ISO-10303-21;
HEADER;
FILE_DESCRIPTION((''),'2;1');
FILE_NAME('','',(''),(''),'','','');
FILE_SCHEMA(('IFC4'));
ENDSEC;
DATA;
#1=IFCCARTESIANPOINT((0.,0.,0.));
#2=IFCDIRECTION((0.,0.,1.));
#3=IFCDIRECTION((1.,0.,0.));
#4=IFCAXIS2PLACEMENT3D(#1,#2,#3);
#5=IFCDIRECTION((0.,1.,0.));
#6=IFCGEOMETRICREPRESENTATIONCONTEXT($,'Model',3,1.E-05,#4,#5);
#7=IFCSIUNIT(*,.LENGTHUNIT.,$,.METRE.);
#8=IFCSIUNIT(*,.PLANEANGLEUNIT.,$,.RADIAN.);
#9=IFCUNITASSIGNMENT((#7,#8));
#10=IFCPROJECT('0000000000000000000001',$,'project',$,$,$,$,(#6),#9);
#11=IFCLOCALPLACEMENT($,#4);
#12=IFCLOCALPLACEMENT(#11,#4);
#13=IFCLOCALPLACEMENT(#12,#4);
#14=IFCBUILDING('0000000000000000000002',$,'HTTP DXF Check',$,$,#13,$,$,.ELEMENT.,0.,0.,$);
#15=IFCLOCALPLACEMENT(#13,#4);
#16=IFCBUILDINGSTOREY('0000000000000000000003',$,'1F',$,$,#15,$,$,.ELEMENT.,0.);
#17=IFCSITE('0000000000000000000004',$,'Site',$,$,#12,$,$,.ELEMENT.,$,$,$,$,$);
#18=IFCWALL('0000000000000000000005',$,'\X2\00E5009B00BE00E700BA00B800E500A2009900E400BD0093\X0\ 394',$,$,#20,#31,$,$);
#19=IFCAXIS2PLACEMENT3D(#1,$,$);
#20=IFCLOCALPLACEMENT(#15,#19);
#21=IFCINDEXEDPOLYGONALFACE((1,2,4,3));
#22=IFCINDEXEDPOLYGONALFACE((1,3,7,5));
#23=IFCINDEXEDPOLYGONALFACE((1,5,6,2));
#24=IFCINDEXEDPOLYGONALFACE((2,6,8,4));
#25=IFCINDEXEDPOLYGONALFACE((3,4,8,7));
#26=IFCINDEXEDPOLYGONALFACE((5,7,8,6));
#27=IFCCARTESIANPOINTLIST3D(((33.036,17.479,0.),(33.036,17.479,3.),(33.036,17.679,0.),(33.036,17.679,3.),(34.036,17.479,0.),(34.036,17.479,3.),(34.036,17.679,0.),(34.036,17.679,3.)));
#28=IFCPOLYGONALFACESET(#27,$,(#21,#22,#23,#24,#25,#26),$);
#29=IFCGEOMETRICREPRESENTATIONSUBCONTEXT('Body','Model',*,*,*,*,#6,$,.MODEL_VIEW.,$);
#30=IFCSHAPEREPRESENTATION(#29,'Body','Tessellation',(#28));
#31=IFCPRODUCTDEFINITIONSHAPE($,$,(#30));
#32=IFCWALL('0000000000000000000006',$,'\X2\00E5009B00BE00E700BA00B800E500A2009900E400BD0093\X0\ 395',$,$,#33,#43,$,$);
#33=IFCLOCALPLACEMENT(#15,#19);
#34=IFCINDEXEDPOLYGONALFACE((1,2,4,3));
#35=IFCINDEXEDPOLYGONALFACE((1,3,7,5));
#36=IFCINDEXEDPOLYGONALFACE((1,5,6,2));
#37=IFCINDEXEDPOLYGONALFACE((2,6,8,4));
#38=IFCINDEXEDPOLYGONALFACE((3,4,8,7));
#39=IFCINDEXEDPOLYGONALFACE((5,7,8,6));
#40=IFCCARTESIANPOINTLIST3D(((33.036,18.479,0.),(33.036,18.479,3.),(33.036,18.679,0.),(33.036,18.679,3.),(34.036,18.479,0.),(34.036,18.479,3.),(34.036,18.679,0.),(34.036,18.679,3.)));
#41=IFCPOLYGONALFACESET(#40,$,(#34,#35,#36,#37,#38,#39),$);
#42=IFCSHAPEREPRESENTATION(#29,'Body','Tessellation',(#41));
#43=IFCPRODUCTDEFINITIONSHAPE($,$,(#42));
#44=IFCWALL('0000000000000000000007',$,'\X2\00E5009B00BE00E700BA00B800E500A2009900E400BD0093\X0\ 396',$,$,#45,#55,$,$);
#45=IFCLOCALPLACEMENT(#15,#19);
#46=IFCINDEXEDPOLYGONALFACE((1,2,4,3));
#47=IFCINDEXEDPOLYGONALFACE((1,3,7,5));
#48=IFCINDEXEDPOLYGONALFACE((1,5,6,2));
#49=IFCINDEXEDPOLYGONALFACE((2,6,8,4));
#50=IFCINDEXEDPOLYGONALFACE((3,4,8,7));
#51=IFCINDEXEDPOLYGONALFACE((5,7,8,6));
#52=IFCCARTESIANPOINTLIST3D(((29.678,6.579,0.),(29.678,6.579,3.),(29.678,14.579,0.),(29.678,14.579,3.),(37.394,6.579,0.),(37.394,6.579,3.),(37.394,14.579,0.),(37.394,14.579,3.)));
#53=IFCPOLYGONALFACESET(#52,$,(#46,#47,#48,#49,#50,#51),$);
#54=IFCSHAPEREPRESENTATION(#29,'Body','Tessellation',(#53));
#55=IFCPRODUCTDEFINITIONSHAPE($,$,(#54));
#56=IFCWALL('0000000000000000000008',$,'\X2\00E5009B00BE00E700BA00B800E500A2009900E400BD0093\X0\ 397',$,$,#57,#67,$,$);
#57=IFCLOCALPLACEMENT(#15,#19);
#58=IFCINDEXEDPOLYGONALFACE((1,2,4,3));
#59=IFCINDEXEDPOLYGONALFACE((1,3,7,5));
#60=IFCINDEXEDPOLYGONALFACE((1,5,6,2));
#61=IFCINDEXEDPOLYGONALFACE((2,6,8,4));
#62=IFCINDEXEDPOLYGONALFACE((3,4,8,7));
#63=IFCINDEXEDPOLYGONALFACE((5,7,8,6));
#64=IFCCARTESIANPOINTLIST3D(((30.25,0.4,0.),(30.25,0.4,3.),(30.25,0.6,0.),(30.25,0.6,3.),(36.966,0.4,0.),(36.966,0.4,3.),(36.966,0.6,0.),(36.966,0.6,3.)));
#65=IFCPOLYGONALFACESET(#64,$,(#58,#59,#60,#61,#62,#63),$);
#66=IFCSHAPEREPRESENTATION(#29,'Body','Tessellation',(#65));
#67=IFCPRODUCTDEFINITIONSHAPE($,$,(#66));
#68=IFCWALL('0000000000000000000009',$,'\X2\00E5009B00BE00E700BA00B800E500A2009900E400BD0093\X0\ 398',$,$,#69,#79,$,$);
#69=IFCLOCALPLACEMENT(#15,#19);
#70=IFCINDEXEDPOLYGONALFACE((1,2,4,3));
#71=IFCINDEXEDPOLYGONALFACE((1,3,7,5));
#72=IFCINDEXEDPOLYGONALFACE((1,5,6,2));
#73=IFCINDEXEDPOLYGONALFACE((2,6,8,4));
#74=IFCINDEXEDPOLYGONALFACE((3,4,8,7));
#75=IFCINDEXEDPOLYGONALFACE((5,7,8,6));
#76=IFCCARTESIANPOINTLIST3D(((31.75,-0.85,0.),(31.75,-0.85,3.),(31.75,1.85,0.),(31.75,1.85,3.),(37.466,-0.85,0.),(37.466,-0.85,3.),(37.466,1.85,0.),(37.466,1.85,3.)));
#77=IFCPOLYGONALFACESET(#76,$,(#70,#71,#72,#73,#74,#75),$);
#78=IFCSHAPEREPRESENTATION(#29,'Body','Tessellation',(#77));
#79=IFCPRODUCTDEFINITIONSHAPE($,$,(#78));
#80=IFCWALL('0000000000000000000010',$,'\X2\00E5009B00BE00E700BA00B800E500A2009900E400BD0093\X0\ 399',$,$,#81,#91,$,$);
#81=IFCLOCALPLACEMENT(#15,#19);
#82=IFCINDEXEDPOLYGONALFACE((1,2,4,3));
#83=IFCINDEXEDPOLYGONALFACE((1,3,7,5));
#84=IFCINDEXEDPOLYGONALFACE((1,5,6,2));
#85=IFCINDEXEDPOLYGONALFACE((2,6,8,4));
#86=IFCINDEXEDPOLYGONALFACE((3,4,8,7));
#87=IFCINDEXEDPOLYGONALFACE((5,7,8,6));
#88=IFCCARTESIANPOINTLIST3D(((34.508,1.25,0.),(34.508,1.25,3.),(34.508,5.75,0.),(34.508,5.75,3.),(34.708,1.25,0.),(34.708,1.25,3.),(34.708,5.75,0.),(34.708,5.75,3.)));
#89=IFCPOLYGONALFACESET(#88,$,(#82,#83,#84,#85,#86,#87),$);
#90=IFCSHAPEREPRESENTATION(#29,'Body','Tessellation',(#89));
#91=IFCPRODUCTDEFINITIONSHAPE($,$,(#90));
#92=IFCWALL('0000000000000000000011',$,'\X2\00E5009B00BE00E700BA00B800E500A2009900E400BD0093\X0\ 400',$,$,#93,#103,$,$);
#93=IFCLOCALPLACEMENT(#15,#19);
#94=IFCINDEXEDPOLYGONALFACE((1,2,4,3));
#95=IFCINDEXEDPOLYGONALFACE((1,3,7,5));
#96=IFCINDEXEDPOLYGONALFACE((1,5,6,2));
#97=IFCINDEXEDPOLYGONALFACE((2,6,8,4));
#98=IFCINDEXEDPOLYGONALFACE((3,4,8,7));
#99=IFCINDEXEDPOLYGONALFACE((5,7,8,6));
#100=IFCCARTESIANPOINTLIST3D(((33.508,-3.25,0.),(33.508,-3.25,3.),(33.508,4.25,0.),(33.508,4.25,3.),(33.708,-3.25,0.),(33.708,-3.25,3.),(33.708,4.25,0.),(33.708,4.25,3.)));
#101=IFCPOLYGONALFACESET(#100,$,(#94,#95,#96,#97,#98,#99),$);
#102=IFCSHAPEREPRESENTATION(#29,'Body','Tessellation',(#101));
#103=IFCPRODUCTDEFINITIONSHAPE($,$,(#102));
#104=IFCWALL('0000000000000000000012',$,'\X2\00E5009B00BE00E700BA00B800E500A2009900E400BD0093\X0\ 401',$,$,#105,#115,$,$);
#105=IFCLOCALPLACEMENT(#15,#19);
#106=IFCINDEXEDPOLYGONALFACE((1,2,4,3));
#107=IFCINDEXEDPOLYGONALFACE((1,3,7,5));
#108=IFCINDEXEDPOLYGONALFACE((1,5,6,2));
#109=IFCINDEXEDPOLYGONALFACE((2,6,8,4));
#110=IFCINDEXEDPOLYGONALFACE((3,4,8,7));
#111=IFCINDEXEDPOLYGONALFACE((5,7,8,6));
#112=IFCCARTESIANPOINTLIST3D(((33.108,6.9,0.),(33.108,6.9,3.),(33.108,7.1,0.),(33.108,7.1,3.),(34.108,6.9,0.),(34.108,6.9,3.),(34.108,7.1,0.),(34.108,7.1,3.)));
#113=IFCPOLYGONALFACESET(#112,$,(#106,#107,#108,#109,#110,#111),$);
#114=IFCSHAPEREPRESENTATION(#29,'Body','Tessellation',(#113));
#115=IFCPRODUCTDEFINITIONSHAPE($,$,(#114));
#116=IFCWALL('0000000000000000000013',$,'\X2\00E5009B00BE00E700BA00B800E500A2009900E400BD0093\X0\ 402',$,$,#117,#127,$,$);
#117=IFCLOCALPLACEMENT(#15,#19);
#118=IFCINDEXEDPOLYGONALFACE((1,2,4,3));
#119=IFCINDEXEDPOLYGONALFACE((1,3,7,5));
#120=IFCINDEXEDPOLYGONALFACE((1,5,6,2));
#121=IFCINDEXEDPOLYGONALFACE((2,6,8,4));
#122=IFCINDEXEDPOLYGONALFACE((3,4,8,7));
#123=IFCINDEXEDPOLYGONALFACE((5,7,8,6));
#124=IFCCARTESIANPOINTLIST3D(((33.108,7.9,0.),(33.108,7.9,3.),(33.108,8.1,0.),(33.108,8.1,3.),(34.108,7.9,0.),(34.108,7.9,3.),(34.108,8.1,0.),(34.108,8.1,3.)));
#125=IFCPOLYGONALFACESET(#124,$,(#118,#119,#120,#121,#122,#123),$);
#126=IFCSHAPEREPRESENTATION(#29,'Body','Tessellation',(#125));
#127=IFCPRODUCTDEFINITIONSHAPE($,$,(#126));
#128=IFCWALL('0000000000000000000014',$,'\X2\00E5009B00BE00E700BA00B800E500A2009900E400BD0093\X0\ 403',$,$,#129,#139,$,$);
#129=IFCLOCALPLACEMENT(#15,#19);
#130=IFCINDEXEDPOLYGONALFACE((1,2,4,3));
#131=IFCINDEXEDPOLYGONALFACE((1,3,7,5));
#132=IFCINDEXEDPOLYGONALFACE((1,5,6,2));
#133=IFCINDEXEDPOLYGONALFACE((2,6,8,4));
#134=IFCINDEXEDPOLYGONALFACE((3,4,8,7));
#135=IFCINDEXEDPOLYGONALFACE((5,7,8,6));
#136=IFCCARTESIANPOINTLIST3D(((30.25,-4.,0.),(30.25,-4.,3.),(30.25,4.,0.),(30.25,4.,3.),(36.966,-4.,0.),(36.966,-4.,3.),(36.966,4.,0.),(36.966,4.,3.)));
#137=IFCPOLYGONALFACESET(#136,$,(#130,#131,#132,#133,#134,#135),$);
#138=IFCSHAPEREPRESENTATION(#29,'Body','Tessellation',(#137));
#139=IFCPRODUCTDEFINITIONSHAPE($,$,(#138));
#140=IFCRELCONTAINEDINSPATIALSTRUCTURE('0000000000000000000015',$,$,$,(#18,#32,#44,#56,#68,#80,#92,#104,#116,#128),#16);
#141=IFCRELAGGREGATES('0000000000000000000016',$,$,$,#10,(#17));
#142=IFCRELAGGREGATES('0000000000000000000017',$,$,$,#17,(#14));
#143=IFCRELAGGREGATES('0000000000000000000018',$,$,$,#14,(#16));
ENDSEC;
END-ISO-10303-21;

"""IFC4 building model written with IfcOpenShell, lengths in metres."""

from ifc_helpers import new_model, si_unit, direction, frame, frame_2d, origin_with_axes, place, context, subcontext, project, spatial, rectangle, extrude, element, save


model = new_model("IFC4")

# Units and contexts
model_context = context("Model", 3, precision=1e-05, world=origin_with_axes(), true_north=direction((0.0, 1.0, 0.0)))
body_context = subcontext(model_context, "Body", "Model", "MODEL_VIEW")
ifc_project = project(units=[si_unit("LENGTHUNIT", "METRE"), si_unit("PLANEANGLEUNIT", "RADIAN")], contexts=[model_context])

# Site, building, storey
placement = place(None, origin_with_axes())
site_placement = place(placement, origin_with_axes())
site = spatial("IfcSite", under=ifc_project, at=site_placement, Name="Site", CompositionType="ELEMENT")
building_placement = place(site_placement, origin_with_axes())
building = spatial("IfcBuilding", under=site, at=building_placement, Name="HTTP DXF Check", CompositionType="ELEMENT", ElevationOfRefHeight=0.0, ElevationOfTerrain=0.0)
storey_placement = place(building_placement, origin_with_axes())
storey = spatial("IfcBuildingStorey", under=building, at=storey_placement, Name="1F", CompositionType="ELEMENT", Elevation=0.0)

# Walls
for number, where, z_axis, x_axis, name in (
    (1, (33.536, 17.579, 0.0), (0.0, 0.0, 1.0), (1.0, 0.0, 0.0), "å\u009b¾çº¸å¢\u0099ä½\u0093 394"),
    (2, (33.536, 18.579, 0.0), (0.0, 0.0, 1.0), (1.0, 0.0, 0.0), "å\u009b¾çº¸å¢\u0099ä½\u0093 395"),
):
    element("IfcWall", number, at=place(storey_placement, frame(where, z_axis=z_axis, x_axis=x_axis)), inside=storey, Name=name, context=body_context, shape_type="SweptSolid", body=[
        extrude(rectangle(XDim=1.0, YDim=0.2, at=frame_2d((0.0, 0.0), x_axis=(1.0, 0.0, 0.0))), frame((0.0, 0.0, 0.0), z_axis=(0.0, 0.0, 1.0)), (0.0, 0.0, 1.0), 3.0),
    ])
wall_1_placement = place(storey_placement, frame((33.536, 10.579, 0.0), z_axis=(0.0, 0.0, 1.0), x_axis=(1.0, 0.0, 0.0)))
element("IfcWall", 3, at=wall_1_placement, inside=storey, Name="å\u009b¾çº¸å¢\u0099ä½\u0093 396", context=body_context, shape_type="SweptSolid", body=[
    extrude(rectangle(XDim=7.716, YDim=8.0, at=frame_2d((0.0, 0.0), x_axis=(1.0, 0.0, 0.0))), frame((0.0, 0.0, 0.0), z_axis=(0.0, 0.0, 1.0)), (0.0, 0.0, 1.0), 3.0),
])
wall_2_placement = place(storey_placement, frame((33.608, 0.5, 0.0), z_axis=(0.0, 0.0, 1.0), x_axis=(1.0, 0.0, 0.0)))
element("IfcWall", 4, at=wall_2_placement, inside=storey, Name="å\u009b¾çº¸å¢\u0099ä½\u0093 397", context=body_context, shape_type="SweptSolid", body=[
    extrude(rectangle(XDim=6.716, YDim=0.2, at=frame_2d((0.0, 0.0), x_axis=(1.0, 0.0, 0.0))), frame((0.0, 0.0, 0.0), z_axis=(0.0, 0.0, 1.0)), (0.0, 0.0, 1.0), 3.0),
])
wall_3_placement = place(storey_placement, frame((34.608, 0.5, 0.0), z_axis=(0.0, 0.0, 1.0), x_axis=(1.0, 0.0, 0.0)))
element("IfcWall", 5, at=wall_3_placement, inside=storey, Name="å\u009b¾çº¸å¢\u0099ä½\u0093 398", context=body_context, shape_type="SweptSolid", body=[
    extrude(rectangle(XDim=5.716, YDim=2.7, at=frame_2d((0.0, 0.0), x_axis=(1.0, 0.0, 0.0))), frame((0.0, 0.0, 0.0), z_axis=(0.0, 0.0, 1.0)), (0.0, 0.0, 1.0), 3.0),
])
wall_4_placement = place(storey_placement, frame((34.608, 3.5, 0.0), z_axis=(0.0, 0.0, 1.0), x_axis=(0.0, 1.0, 0.0)))
element("IfcWall", 6, at=wall_4_placement, inside=storey, Name="å\u009b¾çº¸å¢\u0099ä½\u0093 399", context=body_context, shape_type="SweptSolid", body=[
    extrude(rectangle(XDim=4.5, YDim=0.2, at=frame_2d((0.0, 0.0), x_axis=(1.0, 0.0, 0.0))), frame((0.0, 0.0, 0.0), z_axis=(0.0, 0.0, 1.0)), (0.0, 0.0, 1.0), 3.0),
])
wall_5_placement = place(storey_placement, frame((33.608, 0.5, 0.0), z_axis=(0.0, 0.0, 1.0), x_axis=(0.0, 1.0, 0.0)))
element("IfcWall", 7, at=wall_5_placement, inside=storey, Name="å\u009b¾çº¸å¢\u0099ä½\u0093 400", context=body_context, shape_type="SweptSolid", body=[
    extrude(rectangle(XDim=7.5, YDim=0.2, at=frame_2d((0.0, 0.0), x_axis=(1.0, 0.0, 0.0))), frame((0.0, 0.0, 0.0), z_axis=(0.0, 0.0, 1.0)), (0.0, 0.0, 1.0), 3.0),
])
for number, where, z_axis, x_axis, name in (
    (8, (33.608, 7.0, 0.0), (0.0, 0.0, 1.0), (1.0, 0.0, 0.0), "å\u009b¾çº¸å¢\u0099ä½\u0093 401"),
    (9, (33.608, 8.0, 0.0), (0.0, 0.0, 1.0), (1.0, 0.0, 0.0), "å\u009b¾çº¸å¢\u0099ä½\u0093 402"),
):
    element("IfcWall", number, at=place(storey_placement, frame(where, z_axis=z_axis, x_axis=x_axis)), inside=storey, Name=name, context=body_context, shape_type="SweptSolid", body=[
        extrude(rectangle(XDim=1.0, YDim=0.2, at=frame_2d((0.0, 0.0), x_axis=(1.0, 0.0, 0.0))), frame((0.0, 0.0, 0.0), z_axis=(0.0, 0.0, 1.0)), (0.0, 0.0, 1.0), 3.0),
    ])
wall_6_placement = place(storey_placement, frame((33.608, 0.0, 0.0), z_axis=(0.0, 0.0, 1.0), x_axis=(1.0, 0.0, 0.0)))
element("IfcWall", 10, at=wall_6_placement, inside=storey, Name="å\u009b¾çº¸å¢\u0099ä½\u0093 403", context=body_context, shape_type="SweptSolid", body=[
    extrude(rectangle(XDim=6.716, YDim=8.0, at=frame_2d((0.0, 0.0), x_axis=(1.0, 0.0, 0.0))), frame((0.0, 0.0, 0.0), z_axis=(0.0, 0.0, 1.0)), (0.0, 0.0, 1.0), 3.0),
])

save(model, "model.ifc")
